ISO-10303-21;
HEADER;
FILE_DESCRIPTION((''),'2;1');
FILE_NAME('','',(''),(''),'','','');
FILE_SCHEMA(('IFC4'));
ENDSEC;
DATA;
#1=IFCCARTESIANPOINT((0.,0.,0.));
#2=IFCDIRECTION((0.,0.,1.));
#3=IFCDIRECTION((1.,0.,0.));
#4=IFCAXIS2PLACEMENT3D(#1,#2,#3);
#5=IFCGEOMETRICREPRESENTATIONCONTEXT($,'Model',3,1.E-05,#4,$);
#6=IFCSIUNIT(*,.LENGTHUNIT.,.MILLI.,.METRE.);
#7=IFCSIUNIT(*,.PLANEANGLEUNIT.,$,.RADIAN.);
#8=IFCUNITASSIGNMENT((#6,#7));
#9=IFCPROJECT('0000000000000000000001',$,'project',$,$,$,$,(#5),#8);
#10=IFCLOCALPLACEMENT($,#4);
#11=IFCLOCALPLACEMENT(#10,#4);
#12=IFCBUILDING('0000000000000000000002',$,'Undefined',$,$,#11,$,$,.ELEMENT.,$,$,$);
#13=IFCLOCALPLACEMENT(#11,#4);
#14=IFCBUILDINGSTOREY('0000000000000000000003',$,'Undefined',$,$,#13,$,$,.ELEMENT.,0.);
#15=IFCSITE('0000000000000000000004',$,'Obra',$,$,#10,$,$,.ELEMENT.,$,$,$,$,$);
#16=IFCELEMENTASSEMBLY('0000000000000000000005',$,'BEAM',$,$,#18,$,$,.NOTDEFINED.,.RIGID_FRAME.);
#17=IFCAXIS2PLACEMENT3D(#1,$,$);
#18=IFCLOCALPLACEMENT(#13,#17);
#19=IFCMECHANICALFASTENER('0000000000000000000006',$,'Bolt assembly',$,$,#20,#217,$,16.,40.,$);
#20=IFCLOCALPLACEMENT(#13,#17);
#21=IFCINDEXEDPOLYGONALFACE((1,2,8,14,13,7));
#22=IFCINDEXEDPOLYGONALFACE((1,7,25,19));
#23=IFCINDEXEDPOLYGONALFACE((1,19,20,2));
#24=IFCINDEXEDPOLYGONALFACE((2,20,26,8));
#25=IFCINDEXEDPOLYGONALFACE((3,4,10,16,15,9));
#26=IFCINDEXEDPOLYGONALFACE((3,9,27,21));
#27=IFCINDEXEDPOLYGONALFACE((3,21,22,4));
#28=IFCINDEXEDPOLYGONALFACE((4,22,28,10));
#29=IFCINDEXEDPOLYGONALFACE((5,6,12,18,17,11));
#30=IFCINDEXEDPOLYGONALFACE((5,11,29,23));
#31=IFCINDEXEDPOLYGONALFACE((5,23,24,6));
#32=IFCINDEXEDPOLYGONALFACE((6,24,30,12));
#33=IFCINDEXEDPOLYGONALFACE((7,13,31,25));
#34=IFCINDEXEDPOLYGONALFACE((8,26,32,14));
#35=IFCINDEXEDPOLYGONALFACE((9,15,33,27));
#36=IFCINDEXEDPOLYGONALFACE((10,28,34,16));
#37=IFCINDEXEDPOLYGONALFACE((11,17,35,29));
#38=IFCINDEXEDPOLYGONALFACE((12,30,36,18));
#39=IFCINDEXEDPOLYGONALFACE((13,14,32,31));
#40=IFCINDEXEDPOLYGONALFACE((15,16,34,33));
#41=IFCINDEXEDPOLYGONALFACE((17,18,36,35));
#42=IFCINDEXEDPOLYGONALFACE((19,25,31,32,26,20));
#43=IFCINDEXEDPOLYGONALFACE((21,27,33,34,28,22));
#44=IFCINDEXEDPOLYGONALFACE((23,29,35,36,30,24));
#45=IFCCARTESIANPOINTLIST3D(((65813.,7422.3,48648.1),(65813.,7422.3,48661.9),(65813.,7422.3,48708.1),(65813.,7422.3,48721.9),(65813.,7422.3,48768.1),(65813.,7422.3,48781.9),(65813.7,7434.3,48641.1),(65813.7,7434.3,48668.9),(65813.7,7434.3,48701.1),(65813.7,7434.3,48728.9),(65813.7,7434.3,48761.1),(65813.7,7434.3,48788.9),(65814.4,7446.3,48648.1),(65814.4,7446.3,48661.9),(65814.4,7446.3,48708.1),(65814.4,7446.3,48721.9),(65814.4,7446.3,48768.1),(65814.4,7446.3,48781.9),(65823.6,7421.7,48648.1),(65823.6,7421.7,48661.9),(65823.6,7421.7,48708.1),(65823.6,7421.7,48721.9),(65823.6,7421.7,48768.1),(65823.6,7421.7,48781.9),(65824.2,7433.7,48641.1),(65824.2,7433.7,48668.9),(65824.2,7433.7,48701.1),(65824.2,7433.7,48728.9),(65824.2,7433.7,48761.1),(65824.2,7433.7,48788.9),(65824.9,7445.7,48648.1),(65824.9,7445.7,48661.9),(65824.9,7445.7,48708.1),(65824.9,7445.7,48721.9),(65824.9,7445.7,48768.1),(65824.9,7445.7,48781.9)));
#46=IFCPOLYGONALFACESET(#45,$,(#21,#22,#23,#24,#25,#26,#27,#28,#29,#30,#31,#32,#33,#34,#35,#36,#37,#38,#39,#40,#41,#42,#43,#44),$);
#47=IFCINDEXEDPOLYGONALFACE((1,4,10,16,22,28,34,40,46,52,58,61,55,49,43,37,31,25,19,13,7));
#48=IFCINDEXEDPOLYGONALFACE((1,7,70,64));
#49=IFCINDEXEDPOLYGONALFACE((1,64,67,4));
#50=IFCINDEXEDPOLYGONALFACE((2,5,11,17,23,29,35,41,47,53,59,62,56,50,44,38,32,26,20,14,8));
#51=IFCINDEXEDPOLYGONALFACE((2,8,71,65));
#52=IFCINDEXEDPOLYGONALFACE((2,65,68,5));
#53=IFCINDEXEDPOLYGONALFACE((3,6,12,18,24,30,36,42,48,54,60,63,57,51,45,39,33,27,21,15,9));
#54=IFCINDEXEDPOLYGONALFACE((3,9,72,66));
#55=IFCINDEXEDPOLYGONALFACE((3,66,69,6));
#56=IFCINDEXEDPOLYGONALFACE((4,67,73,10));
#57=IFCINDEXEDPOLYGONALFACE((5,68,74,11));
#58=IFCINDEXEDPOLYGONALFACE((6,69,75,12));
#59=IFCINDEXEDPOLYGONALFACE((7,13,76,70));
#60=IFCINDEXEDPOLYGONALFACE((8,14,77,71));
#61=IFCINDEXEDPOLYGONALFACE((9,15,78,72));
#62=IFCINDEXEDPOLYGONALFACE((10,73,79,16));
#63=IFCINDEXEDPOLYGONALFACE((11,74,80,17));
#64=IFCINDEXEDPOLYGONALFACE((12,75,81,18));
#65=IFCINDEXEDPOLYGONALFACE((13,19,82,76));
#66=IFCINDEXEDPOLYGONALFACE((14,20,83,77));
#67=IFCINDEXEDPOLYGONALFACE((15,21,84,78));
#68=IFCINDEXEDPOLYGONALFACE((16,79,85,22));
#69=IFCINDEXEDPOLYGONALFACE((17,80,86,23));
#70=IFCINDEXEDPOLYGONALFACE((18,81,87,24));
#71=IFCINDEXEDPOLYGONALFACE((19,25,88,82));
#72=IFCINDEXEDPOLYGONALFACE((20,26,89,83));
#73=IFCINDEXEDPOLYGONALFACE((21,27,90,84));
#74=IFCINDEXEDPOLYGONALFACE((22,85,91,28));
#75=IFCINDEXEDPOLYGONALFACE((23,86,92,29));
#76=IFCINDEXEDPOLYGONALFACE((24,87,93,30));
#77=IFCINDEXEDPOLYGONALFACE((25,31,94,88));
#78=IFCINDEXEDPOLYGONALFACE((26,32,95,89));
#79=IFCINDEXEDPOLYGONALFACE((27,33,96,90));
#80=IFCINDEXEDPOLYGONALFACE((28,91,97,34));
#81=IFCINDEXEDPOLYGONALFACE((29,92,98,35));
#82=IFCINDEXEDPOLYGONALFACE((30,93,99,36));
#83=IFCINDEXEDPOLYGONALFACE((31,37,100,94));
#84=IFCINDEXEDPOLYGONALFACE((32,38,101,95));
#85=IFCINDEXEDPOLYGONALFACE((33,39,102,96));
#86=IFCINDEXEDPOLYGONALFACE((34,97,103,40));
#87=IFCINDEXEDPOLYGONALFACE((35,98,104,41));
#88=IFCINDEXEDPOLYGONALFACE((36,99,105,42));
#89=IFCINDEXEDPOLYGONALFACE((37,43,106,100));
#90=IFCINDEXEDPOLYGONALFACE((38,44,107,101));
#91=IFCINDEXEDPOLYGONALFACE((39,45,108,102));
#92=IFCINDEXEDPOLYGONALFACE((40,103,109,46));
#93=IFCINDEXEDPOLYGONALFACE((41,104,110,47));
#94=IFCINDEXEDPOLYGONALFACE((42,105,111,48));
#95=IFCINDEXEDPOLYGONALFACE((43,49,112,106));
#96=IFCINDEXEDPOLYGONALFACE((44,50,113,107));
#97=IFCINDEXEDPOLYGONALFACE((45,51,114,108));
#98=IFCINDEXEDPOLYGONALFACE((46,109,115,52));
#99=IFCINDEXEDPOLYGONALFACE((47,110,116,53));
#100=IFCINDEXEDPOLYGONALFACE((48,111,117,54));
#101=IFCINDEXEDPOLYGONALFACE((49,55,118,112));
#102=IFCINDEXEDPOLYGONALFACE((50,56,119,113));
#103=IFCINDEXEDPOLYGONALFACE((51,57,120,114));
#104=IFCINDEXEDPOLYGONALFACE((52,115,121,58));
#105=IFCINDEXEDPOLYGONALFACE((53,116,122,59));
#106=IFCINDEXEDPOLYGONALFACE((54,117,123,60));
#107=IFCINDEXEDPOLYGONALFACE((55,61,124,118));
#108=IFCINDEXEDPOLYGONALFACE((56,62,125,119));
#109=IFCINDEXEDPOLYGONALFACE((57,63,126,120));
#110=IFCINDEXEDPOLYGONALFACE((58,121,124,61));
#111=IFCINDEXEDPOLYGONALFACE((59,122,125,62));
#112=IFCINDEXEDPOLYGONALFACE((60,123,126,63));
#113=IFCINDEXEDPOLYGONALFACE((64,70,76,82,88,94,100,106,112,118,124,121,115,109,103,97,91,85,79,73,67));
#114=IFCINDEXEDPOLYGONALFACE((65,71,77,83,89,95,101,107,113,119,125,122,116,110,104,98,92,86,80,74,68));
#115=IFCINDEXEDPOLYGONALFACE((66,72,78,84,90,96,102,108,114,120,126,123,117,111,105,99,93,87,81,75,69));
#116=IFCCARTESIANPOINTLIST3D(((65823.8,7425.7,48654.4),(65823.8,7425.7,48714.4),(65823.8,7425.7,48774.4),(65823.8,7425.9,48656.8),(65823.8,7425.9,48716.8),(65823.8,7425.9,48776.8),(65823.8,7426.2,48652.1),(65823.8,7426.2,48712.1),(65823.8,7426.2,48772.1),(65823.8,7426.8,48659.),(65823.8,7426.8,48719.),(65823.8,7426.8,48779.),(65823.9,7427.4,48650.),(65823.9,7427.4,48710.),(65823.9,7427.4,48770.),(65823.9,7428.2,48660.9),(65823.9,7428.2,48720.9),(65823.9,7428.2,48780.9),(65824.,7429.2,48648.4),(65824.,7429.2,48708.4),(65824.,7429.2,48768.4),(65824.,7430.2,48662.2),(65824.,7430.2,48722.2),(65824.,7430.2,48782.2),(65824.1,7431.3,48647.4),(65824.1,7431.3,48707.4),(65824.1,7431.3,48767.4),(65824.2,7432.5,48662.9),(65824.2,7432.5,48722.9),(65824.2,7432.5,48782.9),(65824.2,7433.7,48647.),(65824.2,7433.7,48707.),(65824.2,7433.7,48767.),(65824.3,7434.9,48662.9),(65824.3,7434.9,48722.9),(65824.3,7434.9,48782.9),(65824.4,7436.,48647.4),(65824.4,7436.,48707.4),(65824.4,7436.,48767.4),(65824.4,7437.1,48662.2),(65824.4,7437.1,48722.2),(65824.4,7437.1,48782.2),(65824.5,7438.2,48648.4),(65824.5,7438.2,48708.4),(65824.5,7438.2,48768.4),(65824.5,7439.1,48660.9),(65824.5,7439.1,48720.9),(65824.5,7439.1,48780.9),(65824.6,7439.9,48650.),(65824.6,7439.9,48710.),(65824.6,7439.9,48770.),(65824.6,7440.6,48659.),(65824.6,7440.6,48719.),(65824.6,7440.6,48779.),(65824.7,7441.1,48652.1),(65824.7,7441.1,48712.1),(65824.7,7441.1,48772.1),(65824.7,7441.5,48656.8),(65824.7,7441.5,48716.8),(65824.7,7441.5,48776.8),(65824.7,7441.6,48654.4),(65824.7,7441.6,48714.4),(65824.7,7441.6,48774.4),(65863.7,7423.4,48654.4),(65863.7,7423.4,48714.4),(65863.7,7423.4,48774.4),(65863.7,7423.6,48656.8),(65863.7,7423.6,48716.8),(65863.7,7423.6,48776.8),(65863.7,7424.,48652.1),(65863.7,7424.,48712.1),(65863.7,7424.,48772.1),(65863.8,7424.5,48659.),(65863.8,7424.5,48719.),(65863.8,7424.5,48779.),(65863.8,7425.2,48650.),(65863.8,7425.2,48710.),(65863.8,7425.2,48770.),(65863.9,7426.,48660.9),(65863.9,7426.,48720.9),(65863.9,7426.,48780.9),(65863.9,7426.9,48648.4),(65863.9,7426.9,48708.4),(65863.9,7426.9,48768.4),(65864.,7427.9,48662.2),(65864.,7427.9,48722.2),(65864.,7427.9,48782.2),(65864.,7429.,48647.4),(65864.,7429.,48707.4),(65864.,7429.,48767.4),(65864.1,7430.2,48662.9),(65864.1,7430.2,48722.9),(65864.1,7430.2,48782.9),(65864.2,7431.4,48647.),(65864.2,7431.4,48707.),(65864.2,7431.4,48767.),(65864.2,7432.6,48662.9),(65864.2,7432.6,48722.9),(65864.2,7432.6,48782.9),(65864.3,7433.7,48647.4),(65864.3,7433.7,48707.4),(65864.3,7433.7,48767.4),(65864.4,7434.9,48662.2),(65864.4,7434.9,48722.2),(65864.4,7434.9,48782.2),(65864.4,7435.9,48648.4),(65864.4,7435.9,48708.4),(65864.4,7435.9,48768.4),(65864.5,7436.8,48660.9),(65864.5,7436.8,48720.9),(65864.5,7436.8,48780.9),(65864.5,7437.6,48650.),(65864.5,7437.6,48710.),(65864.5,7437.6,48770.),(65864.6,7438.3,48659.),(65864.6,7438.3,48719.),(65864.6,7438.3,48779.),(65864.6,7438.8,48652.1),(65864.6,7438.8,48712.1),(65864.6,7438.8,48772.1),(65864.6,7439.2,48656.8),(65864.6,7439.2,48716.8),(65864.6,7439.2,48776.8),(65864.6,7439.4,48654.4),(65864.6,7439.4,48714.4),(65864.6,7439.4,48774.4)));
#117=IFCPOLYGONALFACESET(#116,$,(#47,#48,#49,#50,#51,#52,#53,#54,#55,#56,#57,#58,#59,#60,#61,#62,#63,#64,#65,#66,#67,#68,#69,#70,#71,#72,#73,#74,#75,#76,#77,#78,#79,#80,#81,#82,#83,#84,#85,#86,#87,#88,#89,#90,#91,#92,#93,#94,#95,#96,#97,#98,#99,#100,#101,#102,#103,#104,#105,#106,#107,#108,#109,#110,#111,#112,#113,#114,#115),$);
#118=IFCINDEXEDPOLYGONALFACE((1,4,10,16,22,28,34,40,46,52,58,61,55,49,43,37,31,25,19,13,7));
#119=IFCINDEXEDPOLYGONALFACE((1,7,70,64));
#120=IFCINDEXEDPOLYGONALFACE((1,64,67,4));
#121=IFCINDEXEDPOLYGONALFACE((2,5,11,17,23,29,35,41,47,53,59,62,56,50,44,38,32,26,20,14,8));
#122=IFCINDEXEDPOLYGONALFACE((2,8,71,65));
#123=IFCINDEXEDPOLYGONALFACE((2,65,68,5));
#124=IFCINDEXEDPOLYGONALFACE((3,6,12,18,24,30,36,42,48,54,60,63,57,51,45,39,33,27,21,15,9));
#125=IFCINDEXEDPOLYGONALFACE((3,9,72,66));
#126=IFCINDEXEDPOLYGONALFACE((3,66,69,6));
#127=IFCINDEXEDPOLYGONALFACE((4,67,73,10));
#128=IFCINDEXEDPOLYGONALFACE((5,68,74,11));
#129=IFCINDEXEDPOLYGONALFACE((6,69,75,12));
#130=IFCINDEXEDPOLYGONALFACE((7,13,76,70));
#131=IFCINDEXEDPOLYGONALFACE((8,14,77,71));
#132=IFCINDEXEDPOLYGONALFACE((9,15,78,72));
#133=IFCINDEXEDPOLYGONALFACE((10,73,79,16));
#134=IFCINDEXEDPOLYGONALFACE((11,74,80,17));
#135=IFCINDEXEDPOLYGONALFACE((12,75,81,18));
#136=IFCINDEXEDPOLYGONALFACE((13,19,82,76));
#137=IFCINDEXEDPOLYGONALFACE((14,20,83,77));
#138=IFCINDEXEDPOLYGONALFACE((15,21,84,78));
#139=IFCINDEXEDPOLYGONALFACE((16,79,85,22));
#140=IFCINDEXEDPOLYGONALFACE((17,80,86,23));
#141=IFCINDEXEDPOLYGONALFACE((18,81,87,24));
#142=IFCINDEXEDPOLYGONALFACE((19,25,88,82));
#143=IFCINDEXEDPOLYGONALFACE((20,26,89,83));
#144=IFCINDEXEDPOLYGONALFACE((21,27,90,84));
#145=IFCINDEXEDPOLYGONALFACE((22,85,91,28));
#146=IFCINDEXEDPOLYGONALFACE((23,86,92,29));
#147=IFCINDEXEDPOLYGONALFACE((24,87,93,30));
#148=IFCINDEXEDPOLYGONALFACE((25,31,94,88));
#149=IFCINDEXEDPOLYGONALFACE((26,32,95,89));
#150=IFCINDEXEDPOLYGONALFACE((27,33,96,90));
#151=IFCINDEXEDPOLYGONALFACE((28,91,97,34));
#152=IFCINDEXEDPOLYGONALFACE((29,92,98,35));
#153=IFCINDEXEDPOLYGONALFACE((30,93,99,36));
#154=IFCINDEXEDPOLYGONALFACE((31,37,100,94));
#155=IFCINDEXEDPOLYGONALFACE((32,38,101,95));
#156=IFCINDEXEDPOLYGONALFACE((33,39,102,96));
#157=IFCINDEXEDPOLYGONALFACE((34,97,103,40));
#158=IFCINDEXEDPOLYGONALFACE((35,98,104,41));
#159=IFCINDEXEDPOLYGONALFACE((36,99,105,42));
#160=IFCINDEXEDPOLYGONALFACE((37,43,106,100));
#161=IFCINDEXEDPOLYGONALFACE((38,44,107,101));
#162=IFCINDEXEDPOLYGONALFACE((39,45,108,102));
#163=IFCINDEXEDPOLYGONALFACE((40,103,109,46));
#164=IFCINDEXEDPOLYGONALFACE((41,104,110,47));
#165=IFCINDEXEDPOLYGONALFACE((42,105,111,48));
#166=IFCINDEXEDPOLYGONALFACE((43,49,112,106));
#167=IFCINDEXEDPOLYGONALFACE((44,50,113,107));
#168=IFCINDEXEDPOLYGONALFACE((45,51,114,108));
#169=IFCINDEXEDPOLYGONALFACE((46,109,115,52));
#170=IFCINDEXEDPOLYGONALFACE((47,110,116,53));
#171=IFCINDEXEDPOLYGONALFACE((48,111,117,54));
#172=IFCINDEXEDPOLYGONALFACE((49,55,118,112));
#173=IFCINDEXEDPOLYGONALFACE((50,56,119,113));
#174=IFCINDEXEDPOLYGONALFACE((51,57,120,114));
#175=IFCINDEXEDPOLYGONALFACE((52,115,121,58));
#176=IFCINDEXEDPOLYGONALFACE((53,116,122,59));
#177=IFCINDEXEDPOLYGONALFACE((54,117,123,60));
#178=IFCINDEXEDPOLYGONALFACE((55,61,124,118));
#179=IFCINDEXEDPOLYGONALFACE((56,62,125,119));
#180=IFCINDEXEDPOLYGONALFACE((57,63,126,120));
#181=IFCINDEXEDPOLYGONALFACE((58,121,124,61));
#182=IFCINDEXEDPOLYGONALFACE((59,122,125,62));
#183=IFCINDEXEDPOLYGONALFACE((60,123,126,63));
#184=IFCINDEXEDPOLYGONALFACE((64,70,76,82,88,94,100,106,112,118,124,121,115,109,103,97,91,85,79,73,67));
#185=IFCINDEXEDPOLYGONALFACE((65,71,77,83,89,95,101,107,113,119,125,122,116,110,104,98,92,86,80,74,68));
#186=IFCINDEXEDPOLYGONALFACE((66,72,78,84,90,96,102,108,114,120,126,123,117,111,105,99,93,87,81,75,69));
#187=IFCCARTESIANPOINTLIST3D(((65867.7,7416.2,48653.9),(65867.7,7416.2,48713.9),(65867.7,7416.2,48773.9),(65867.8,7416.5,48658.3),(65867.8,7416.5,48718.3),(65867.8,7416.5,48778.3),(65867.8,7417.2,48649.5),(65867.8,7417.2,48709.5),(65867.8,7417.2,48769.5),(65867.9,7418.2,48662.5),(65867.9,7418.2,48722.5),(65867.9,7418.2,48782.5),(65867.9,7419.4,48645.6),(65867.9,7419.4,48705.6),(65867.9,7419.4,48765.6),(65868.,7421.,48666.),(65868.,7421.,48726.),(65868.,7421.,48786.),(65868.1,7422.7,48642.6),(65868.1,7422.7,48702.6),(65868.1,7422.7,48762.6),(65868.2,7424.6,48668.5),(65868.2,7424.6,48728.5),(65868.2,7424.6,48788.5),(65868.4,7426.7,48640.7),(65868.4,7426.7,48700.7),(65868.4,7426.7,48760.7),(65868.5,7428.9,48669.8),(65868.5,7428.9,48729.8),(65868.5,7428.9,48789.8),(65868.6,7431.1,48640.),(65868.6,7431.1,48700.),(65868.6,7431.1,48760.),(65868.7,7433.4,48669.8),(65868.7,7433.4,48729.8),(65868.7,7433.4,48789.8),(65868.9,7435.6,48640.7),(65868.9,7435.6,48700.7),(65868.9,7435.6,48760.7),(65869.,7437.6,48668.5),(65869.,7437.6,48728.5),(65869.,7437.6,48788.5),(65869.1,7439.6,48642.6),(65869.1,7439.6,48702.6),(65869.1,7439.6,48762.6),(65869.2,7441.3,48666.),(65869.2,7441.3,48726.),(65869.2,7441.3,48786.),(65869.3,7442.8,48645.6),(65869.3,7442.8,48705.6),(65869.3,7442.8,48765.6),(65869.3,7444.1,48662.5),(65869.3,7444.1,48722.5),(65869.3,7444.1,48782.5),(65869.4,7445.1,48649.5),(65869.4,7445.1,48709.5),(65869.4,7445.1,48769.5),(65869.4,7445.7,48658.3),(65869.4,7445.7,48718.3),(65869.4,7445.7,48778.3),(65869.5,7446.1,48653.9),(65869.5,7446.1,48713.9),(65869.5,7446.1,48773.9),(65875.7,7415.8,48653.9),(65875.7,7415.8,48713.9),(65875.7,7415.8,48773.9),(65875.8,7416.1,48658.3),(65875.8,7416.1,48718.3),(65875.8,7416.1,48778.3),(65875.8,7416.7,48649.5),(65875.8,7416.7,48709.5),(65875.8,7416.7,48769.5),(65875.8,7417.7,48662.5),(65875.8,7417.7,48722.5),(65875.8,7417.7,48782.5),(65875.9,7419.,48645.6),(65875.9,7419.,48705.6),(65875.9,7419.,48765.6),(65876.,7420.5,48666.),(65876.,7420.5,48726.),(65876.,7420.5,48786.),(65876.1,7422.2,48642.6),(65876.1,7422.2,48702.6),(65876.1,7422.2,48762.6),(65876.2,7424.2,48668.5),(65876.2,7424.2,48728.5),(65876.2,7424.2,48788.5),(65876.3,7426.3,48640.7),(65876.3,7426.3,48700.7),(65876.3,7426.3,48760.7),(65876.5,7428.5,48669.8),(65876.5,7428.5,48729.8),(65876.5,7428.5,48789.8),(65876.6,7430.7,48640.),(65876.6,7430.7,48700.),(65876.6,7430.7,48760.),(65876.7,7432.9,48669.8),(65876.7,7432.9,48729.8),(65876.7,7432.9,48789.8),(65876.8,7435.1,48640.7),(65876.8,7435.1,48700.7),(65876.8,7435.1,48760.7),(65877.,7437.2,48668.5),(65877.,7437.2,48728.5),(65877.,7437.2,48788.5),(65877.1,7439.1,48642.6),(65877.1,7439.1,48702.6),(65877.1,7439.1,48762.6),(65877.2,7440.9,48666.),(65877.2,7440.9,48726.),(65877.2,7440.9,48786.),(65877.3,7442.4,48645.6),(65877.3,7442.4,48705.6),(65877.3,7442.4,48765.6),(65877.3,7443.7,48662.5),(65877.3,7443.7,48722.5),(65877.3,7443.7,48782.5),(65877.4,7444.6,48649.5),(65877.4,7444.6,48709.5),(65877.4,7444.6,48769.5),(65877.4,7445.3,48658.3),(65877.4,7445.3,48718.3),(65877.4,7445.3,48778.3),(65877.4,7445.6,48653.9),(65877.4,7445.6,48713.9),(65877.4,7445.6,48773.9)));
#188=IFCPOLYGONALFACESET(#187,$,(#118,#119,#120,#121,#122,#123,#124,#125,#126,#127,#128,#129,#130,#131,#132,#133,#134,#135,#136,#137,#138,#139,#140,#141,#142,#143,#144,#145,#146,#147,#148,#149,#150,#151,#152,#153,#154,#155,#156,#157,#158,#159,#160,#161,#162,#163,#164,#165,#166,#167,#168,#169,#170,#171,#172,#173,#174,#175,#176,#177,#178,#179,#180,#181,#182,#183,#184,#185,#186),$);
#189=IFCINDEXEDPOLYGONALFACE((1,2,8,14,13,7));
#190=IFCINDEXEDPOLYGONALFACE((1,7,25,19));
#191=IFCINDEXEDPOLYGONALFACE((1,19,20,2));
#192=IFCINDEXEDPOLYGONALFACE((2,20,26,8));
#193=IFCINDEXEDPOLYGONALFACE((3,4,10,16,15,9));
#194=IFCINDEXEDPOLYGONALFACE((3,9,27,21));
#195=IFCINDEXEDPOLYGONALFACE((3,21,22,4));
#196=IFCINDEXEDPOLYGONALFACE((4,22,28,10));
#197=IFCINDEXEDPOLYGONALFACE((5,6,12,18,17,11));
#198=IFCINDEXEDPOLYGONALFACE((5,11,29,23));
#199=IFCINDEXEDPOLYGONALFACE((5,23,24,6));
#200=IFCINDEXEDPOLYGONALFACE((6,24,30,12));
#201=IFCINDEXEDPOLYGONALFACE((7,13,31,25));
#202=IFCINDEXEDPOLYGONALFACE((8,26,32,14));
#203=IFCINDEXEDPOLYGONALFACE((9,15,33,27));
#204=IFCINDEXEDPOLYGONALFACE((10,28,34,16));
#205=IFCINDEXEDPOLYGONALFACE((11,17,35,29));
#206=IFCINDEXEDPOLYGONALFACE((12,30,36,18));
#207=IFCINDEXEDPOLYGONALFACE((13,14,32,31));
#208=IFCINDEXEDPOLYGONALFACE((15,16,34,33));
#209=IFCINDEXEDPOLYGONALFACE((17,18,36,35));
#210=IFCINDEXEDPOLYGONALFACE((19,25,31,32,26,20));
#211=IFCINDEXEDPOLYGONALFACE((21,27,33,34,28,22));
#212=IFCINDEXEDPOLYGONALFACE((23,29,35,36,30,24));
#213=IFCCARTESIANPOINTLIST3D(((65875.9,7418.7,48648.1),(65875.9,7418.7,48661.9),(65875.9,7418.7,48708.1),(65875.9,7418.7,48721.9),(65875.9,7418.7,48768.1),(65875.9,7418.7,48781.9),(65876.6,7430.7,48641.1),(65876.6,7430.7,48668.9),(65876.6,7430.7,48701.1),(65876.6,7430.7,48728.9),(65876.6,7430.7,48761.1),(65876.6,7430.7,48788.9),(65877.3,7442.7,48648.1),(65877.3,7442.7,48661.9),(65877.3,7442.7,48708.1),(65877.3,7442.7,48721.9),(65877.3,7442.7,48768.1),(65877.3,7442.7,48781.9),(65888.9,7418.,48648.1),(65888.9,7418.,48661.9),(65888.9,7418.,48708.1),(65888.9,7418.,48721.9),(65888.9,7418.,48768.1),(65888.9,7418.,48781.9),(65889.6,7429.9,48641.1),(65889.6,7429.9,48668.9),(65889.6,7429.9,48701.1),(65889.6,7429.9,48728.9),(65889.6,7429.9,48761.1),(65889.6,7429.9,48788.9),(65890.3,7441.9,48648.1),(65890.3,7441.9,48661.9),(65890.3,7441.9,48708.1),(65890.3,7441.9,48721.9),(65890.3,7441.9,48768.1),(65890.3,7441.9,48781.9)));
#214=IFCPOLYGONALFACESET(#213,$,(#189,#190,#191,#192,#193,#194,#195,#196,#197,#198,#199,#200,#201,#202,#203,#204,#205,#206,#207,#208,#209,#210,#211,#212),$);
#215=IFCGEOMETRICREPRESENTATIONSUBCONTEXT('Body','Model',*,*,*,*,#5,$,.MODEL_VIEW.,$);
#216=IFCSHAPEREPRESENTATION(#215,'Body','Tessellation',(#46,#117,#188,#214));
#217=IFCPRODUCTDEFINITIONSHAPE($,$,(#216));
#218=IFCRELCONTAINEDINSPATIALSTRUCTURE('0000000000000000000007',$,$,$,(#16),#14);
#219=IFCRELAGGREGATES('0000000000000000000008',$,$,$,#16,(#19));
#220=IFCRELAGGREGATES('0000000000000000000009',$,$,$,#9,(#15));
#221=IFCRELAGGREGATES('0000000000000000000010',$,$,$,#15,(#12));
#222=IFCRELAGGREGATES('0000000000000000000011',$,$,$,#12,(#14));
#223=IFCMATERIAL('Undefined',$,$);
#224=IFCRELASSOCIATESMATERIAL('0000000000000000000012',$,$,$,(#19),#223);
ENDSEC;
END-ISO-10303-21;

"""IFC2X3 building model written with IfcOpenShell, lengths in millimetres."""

from ifc_helpers import new_model, si_unit, frame, origin_with_axes, origin_2d_with_axis, place, context, subcontext, project, spatial, polyline, circle, outline, extrude, source, transform, mapped, material, element, aggregate, save


model = new_model("IFC2X3")

# Units and contexts
model_context = context("Model", 3, precision=1e-05, world=origin_with_axes())
body_context = subcontext(model_context, "Body", "Model", "MODEL_VIEW")
ifc_project = project(units=[si_unit("LENGTHUNIT", "METRE", prefix="MILLI"), si_unit("PLANEANGLEUNIT", "RADIAN")], contexts=[model_context])

# Site, building, storey
site_placement = place(None, origin_with_axes())
site = spatial("IfcSite", under=ifc_project, at=site_placement, Name="Obra", CompositionType="ELEMENT")
building_placement = place(site_placement, origin_with_axes())
building = spatial("IfcBuilding", under=site, at=building_placement, Name="Undefined", CompositionType="ELEMENT")
storey_placement = place(building_placement, origin_with_axes())
storey = spatial("IfcBuildingStorey", under=building, at=storey_placement, Name="Undefined", CompositionType="ELEMENT", Elevation=0.0)

# Element assembly
assembly_1_placement = place(storey_placement, origin_with_axes())
assembly_1 = element("IfcElementAssembly", 1, at=assembly_1_placement, inside=storey, Name="BEAM", AssemblyPlace="NOTDEFINED", PredefinedType="RIGID_FRAME")

# Mechanical fastener
ifc_material_1 = material(Name="Undefined")
shared_shape_1 = source(origin_with_axes(), body_context, "Body", "SweptSolid", [
    extrude(outline(polyline([(13.9, 0.0), (6.9, 12.0), (-6.9, 12.0), (-13.9, 0.0), (-6.9, -12.0), (6.9, -12.0), (13.9, 0.0)])), frame((0.0, -19.7, 0.0), z_axis=(0.0, 1.0, 0.0), x_axis=(1.0, 0.0, 0.0)), (0.0, 0.0, 1.0), 10.6),
    extrude(circle(Radius=8.0, at=origin_2d_with_axis()), frame((0.0, -9.1, 0.0), z_axis=(0.0, 1.0, 0.0), x_axis=(1.0, 0.0, 0.0)), (0.0, 0.0, 1.0), 40.0),
    extrude(circle(Radius=15.0, at=origin_2d_with_axis()), frame((0.0, 35.3, 0.0), z_axis=(0.0, 1.0, 0.0), x_axis=(1.0, 0.0, 0.0)), (0.0, 0.0, 1.0), 8.0),
    extrude(outline(polyline([(13.9, 0.0), (6.9, 12.0), (-6.9, 12.0), (-13.9, 0.0), (-6.9, -12.0), (6.9, -12.0), (13.9, 0.0)])), frame((0.0, 43.3, 0.0), z_axis=(0.0, 1.0, 0.0), x_axis=(1.0, 0.0, 0.0)), (0.0, 0.0, 1.0), 13.0),
])
mechanical_fastener_1_placement = place(assembly_1_placement, frame((65836.2, 7483.1, 48835.0), z_axis=(-0.05711, -0.998368, 0.0), x_axis=(0.0, 0.0, -1.0)))
mechanical_fastener_1 = element("IfcMechanicalFastener", 2, at=mechanical_fastener_1_placement, material=ifc_material_1, Name="Bolt assembly", NominalDiameter=16.0, NominalLength=40.0, context=body_context, shape_type="MappedRepresentation", body=[
    mapped(shared_shape_1, transform((60.0, 0.0, 50.0))),
    mapped(shared_shape_1, transform((120.0, 0.0, 50.0))),
    mapped(shared_shape_1, transform((180.0, 0.0, 50.0))),
])
aggregate(assembly_1, [mechanical_fastener_1])

save(model, "model.ifc")
